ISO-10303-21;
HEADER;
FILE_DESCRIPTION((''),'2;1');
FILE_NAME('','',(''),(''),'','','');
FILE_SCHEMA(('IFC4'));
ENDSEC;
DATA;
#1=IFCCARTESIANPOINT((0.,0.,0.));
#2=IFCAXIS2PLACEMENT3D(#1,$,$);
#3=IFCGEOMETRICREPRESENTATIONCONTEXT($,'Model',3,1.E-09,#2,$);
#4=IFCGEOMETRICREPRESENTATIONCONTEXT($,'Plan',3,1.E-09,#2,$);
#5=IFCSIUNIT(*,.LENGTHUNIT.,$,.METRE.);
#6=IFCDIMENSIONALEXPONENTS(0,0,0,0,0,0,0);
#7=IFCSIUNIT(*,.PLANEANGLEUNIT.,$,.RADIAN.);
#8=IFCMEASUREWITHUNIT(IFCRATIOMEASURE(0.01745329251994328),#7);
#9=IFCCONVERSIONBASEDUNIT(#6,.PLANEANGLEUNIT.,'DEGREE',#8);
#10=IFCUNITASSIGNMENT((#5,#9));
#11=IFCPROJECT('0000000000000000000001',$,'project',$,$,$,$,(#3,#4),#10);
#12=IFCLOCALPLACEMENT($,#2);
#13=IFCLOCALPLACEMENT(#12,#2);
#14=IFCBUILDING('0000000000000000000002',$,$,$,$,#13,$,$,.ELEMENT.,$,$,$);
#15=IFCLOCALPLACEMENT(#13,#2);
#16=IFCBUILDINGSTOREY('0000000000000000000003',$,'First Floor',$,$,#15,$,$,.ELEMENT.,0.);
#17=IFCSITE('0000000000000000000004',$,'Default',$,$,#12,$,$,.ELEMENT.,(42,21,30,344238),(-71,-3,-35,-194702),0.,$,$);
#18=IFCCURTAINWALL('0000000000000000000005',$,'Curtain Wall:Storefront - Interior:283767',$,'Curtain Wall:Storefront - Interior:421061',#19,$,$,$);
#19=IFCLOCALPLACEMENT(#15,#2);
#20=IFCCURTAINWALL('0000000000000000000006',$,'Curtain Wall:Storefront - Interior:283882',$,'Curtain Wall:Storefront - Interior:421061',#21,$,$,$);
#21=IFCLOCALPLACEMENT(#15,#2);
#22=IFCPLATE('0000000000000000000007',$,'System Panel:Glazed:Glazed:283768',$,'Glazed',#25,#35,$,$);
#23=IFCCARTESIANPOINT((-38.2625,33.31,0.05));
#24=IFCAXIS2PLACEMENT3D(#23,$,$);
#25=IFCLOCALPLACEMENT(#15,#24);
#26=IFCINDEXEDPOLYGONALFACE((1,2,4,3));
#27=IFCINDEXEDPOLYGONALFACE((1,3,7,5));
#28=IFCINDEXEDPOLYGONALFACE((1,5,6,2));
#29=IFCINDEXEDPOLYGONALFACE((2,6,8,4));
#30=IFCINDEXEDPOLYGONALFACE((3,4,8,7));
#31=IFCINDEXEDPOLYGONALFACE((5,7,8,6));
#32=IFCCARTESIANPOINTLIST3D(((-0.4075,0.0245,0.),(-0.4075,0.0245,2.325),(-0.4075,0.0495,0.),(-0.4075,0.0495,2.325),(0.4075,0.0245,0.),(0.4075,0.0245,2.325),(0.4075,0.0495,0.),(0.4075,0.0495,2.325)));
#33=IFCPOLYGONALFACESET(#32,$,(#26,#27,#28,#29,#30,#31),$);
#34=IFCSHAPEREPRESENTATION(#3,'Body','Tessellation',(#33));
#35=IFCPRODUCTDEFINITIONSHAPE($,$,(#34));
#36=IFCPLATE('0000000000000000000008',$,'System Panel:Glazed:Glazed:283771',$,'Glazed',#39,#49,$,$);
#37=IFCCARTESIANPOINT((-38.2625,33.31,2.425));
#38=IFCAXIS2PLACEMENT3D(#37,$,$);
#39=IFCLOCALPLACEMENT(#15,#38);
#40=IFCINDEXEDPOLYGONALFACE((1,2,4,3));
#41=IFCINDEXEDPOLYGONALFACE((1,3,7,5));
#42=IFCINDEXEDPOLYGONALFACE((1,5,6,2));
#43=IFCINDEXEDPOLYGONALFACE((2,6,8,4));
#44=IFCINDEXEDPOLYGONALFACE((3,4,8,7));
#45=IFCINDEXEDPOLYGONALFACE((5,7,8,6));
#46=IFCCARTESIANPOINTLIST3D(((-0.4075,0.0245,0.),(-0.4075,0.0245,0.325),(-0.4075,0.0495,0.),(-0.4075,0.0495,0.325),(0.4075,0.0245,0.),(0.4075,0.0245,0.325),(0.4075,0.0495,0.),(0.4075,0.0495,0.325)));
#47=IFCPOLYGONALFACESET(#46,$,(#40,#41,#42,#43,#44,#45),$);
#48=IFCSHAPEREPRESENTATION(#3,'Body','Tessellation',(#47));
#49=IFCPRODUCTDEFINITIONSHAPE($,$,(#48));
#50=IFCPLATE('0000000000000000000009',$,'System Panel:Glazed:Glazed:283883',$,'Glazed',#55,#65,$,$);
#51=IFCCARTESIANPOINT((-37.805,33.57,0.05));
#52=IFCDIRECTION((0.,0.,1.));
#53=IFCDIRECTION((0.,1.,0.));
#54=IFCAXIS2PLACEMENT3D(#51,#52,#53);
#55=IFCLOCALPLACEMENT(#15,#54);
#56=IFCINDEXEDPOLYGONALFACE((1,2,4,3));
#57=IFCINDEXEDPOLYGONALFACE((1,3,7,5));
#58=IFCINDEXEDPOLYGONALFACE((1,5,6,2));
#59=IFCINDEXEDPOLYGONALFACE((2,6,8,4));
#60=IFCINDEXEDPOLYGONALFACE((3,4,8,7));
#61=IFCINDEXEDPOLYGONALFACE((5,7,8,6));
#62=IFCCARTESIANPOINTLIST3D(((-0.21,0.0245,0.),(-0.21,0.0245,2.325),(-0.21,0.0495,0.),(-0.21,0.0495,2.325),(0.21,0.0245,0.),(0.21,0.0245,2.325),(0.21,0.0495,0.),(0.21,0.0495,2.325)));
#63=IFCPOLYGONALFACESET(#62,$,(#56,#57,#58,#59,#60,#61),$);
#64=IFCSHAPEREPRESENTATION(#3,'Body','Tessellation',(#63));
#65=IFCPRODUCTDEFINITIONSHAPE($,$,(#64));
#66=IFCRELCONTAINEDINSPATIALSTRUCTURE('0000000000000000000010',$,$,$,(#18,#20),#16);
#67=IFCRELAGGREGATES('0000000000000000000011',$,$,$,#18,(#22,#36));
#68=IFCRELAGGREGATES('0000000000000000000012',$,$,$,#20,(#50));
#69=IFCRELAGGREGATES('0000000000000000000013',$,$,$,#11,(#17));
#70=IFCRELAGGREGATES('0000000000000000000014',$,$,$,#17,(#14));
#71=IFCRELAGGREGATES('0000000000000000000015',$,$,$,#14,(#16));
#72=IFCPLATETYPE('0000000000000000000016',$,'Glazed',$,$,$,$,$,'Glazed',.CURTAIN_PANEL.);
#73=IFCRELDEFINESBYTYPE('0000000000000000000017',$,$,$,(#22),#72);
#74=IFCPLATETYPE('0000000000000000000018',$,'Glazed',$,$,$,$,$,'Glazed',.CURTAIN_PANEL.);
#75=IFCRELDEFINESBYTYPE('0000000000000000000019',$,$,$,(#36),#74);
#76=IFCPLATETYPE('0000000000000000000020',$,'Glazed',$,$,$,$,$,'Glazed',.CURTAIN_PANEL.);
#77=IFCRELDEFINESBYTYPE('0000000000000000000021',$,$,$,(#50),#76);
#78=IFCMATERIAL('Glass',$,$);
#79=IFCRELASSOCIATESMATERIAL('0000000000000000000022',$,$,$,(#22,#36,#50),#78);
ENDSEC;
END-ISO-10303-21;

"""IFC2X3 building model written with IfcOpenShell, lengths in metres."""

from ifc_helpers import new_model, entity, si_unit, converted_unit, frame, origin, origin_2d_with_axis, place, context, project, spatial, rectangle, extrude, source, transform, mapped, material, type_object, type_shapes, element, aggregate, save


model = new_model("IFC2X3")

# Units and contexts
model_context = context("Model", 3, precision=1e-09, world=origin())
plan_context = context("Plan", 3, precision=1e-09, world=origin())
ifc_project = project(units=[si_unit("LENGTHUNIT", "METRE"), converted_unit("PLANEANGLEUNIT", "DEGREE", entity("IfcRatioMeasure", 0.01745329251994328), si_unit("PLANEANGLEUNIT", "RADIAN"), dimensions=[0, 0, 0, 0, 0, 0, 0])], contexts=[model_context, plan_context])

# Site, building, storey
site_placement = place(None, origin())
site = spatial("IfcSite", under=ifc_project, at=site_placement, Name="Default", CompositionType="ELEMENT", RefLatitude=(42, 21, 30, 344238), RefLongitude=(-71, -3, -35, -194702), RefElevation=0.0)
building_placement = place(site_placement, origin())
building = spatial("IfcBuilding", under=site, at=building_placement, CompositionType="ELEMENT")
storey_placement = place(building_placement, origin())
storey = spatial("IfcBuildingStorey", under=building, at=storey_placement, Name="First Floor", CompositionType="ELEMENT", Elevation=0.0)

# Curtain wall
curtain_wall_1_placement = place(storey_placement, origin())
curtain_wall_1 = element("IfcCurtainWall", 1, at=curtain_wall_1_placement, inside=storey, Name="Curtain Wall:Storefront - Interior:283767", ObjectType="Curtain Wall:Storefront - Interior:421061")

# Curtain wall
curtain_wall_2_placement = place(storey_placement, origin())
curtain_wall_2 = element("IfcCurtainWall", 2, at=curtain_wall_2_placement, inside=storey, Name="Curtain Wall:Storefront - Interior:283882", ObjectType="Curtain Wall:Storefront - Interior:421061")

# Plates
ifc_material_1 = material(Name="Glass")
plate_type_1 = type_object("IfcPlateType", Name="Glazed", ElementType="Glazed", PredefinedType="CURTAIN_PANEL")
shared_shape_1 = source(origin(), model_context, "Body", "SweptSolid", [
    extrude(rectangle(XDim=0.025, YDim=0.815, at=origin_2d_with_axis()), frame((0.0, 0.037, 0.0), z_axis=(0.0, 0.0, 1.0), x_axis=(0.0, 1.0, 0.0)), (0.0, 0.0, 1.0), 2.325),
])
type_shapes(plate_type_1, [shared_shape_1])
plate_1_placement = place(storey_placement, frame((-38.2625, 33.31, 0.05)))
plate_1 = element("IfcPlate", 3, at=plate_1_placement, type_object=plate_type_1, material=ifc_material_1, Name="System Panel:Glazed:Glazed:283768", ObjectType="Glazed", context=model_context, shape_type="MappedRepresentation", body=[
    mapped(shared_shape_1, transform((0.0, 0.0, 0.0), scale=1.0)),
])
plate_type_2 = type_object("IfcPlateType", Name="Glazed", ElementType="Glazed", PredefinedType="CURTAIN_PANEL")
shared_shape_2 = source(origin(), model_context, "Body", "SweptSolid", [
    extrude(rectangle(XDim=0.025, YDim=0.815, at=origin_2d_with_axis()), frame((0.0, 0.037, 0.0), z_axis=(0.0, 0.0, 1.0), x_axis=(0.0, 1.0, 0.0)), (0.0, 0.0, 1.0), 0.325),
])
type_shapes(plate_type_2, [shared_shape_2])
plate_2_placement = place(storey_placement, frame((-38.2625, 33.31, 2.425)))
plate_2 = element("IfcPlate", 4, at=plate_2_placement, type_object=plate_type_2, material=ifc_material_1, Name="System Panel:Glazed:Glazed:283771", ObjectType="Glazed", context=model_context, shape_type="MappedRepresentation", body=[
    mapped(shared_shape_2, transform((0.0, 0.0, 0.0), scale=1.0)),
])
aggregate(curtain_wall_1, [plate_1, plate_2])
plate_type_3 = type_object("IfcPlateType", Name="Glazed", ElementType="Glazed", PredefinedType="CURTAIN_PANEL")
shared_shape_3 = source(origin(), model_context, "Body", "SweptSolid", [
    extrude(rectangle(XDim=0.025, YDim=0.42, at=origin_2d_with_axis()), frame((0.0, 0.037, 0.0), z_axis=(0.0, 0.0, 1.0), x_axis=(0.0, 1.0, 0.0)), (0.0, 0.0, 1.0), 2.325),
])
type_shapes(plate_type_3, [shared_shape_3])
plate_3_placement = place(storey_placement, frame((-37.805, 33.57, 0.05), z_axis=(0.0, 0.0, 1.0), x_axis=(0.0, 1.0, 0.0)))
plate_3 = element("IfcPlate", 5, at=plate_3_placement, type_object=plate_type_3, material=ifc_material_1, Name="System Panel:Glazed:Glazed:283883", ObjectType="Glazed", context=model_context, shape_type="MappedRepresentation", body=[
    mapped(shared_shape_3, transform((0.0, 0.0, 0.0), scale=1.0)),
])

aggregate(curtain_wall_2, [plate_3])

save(model, "model.ifc")
